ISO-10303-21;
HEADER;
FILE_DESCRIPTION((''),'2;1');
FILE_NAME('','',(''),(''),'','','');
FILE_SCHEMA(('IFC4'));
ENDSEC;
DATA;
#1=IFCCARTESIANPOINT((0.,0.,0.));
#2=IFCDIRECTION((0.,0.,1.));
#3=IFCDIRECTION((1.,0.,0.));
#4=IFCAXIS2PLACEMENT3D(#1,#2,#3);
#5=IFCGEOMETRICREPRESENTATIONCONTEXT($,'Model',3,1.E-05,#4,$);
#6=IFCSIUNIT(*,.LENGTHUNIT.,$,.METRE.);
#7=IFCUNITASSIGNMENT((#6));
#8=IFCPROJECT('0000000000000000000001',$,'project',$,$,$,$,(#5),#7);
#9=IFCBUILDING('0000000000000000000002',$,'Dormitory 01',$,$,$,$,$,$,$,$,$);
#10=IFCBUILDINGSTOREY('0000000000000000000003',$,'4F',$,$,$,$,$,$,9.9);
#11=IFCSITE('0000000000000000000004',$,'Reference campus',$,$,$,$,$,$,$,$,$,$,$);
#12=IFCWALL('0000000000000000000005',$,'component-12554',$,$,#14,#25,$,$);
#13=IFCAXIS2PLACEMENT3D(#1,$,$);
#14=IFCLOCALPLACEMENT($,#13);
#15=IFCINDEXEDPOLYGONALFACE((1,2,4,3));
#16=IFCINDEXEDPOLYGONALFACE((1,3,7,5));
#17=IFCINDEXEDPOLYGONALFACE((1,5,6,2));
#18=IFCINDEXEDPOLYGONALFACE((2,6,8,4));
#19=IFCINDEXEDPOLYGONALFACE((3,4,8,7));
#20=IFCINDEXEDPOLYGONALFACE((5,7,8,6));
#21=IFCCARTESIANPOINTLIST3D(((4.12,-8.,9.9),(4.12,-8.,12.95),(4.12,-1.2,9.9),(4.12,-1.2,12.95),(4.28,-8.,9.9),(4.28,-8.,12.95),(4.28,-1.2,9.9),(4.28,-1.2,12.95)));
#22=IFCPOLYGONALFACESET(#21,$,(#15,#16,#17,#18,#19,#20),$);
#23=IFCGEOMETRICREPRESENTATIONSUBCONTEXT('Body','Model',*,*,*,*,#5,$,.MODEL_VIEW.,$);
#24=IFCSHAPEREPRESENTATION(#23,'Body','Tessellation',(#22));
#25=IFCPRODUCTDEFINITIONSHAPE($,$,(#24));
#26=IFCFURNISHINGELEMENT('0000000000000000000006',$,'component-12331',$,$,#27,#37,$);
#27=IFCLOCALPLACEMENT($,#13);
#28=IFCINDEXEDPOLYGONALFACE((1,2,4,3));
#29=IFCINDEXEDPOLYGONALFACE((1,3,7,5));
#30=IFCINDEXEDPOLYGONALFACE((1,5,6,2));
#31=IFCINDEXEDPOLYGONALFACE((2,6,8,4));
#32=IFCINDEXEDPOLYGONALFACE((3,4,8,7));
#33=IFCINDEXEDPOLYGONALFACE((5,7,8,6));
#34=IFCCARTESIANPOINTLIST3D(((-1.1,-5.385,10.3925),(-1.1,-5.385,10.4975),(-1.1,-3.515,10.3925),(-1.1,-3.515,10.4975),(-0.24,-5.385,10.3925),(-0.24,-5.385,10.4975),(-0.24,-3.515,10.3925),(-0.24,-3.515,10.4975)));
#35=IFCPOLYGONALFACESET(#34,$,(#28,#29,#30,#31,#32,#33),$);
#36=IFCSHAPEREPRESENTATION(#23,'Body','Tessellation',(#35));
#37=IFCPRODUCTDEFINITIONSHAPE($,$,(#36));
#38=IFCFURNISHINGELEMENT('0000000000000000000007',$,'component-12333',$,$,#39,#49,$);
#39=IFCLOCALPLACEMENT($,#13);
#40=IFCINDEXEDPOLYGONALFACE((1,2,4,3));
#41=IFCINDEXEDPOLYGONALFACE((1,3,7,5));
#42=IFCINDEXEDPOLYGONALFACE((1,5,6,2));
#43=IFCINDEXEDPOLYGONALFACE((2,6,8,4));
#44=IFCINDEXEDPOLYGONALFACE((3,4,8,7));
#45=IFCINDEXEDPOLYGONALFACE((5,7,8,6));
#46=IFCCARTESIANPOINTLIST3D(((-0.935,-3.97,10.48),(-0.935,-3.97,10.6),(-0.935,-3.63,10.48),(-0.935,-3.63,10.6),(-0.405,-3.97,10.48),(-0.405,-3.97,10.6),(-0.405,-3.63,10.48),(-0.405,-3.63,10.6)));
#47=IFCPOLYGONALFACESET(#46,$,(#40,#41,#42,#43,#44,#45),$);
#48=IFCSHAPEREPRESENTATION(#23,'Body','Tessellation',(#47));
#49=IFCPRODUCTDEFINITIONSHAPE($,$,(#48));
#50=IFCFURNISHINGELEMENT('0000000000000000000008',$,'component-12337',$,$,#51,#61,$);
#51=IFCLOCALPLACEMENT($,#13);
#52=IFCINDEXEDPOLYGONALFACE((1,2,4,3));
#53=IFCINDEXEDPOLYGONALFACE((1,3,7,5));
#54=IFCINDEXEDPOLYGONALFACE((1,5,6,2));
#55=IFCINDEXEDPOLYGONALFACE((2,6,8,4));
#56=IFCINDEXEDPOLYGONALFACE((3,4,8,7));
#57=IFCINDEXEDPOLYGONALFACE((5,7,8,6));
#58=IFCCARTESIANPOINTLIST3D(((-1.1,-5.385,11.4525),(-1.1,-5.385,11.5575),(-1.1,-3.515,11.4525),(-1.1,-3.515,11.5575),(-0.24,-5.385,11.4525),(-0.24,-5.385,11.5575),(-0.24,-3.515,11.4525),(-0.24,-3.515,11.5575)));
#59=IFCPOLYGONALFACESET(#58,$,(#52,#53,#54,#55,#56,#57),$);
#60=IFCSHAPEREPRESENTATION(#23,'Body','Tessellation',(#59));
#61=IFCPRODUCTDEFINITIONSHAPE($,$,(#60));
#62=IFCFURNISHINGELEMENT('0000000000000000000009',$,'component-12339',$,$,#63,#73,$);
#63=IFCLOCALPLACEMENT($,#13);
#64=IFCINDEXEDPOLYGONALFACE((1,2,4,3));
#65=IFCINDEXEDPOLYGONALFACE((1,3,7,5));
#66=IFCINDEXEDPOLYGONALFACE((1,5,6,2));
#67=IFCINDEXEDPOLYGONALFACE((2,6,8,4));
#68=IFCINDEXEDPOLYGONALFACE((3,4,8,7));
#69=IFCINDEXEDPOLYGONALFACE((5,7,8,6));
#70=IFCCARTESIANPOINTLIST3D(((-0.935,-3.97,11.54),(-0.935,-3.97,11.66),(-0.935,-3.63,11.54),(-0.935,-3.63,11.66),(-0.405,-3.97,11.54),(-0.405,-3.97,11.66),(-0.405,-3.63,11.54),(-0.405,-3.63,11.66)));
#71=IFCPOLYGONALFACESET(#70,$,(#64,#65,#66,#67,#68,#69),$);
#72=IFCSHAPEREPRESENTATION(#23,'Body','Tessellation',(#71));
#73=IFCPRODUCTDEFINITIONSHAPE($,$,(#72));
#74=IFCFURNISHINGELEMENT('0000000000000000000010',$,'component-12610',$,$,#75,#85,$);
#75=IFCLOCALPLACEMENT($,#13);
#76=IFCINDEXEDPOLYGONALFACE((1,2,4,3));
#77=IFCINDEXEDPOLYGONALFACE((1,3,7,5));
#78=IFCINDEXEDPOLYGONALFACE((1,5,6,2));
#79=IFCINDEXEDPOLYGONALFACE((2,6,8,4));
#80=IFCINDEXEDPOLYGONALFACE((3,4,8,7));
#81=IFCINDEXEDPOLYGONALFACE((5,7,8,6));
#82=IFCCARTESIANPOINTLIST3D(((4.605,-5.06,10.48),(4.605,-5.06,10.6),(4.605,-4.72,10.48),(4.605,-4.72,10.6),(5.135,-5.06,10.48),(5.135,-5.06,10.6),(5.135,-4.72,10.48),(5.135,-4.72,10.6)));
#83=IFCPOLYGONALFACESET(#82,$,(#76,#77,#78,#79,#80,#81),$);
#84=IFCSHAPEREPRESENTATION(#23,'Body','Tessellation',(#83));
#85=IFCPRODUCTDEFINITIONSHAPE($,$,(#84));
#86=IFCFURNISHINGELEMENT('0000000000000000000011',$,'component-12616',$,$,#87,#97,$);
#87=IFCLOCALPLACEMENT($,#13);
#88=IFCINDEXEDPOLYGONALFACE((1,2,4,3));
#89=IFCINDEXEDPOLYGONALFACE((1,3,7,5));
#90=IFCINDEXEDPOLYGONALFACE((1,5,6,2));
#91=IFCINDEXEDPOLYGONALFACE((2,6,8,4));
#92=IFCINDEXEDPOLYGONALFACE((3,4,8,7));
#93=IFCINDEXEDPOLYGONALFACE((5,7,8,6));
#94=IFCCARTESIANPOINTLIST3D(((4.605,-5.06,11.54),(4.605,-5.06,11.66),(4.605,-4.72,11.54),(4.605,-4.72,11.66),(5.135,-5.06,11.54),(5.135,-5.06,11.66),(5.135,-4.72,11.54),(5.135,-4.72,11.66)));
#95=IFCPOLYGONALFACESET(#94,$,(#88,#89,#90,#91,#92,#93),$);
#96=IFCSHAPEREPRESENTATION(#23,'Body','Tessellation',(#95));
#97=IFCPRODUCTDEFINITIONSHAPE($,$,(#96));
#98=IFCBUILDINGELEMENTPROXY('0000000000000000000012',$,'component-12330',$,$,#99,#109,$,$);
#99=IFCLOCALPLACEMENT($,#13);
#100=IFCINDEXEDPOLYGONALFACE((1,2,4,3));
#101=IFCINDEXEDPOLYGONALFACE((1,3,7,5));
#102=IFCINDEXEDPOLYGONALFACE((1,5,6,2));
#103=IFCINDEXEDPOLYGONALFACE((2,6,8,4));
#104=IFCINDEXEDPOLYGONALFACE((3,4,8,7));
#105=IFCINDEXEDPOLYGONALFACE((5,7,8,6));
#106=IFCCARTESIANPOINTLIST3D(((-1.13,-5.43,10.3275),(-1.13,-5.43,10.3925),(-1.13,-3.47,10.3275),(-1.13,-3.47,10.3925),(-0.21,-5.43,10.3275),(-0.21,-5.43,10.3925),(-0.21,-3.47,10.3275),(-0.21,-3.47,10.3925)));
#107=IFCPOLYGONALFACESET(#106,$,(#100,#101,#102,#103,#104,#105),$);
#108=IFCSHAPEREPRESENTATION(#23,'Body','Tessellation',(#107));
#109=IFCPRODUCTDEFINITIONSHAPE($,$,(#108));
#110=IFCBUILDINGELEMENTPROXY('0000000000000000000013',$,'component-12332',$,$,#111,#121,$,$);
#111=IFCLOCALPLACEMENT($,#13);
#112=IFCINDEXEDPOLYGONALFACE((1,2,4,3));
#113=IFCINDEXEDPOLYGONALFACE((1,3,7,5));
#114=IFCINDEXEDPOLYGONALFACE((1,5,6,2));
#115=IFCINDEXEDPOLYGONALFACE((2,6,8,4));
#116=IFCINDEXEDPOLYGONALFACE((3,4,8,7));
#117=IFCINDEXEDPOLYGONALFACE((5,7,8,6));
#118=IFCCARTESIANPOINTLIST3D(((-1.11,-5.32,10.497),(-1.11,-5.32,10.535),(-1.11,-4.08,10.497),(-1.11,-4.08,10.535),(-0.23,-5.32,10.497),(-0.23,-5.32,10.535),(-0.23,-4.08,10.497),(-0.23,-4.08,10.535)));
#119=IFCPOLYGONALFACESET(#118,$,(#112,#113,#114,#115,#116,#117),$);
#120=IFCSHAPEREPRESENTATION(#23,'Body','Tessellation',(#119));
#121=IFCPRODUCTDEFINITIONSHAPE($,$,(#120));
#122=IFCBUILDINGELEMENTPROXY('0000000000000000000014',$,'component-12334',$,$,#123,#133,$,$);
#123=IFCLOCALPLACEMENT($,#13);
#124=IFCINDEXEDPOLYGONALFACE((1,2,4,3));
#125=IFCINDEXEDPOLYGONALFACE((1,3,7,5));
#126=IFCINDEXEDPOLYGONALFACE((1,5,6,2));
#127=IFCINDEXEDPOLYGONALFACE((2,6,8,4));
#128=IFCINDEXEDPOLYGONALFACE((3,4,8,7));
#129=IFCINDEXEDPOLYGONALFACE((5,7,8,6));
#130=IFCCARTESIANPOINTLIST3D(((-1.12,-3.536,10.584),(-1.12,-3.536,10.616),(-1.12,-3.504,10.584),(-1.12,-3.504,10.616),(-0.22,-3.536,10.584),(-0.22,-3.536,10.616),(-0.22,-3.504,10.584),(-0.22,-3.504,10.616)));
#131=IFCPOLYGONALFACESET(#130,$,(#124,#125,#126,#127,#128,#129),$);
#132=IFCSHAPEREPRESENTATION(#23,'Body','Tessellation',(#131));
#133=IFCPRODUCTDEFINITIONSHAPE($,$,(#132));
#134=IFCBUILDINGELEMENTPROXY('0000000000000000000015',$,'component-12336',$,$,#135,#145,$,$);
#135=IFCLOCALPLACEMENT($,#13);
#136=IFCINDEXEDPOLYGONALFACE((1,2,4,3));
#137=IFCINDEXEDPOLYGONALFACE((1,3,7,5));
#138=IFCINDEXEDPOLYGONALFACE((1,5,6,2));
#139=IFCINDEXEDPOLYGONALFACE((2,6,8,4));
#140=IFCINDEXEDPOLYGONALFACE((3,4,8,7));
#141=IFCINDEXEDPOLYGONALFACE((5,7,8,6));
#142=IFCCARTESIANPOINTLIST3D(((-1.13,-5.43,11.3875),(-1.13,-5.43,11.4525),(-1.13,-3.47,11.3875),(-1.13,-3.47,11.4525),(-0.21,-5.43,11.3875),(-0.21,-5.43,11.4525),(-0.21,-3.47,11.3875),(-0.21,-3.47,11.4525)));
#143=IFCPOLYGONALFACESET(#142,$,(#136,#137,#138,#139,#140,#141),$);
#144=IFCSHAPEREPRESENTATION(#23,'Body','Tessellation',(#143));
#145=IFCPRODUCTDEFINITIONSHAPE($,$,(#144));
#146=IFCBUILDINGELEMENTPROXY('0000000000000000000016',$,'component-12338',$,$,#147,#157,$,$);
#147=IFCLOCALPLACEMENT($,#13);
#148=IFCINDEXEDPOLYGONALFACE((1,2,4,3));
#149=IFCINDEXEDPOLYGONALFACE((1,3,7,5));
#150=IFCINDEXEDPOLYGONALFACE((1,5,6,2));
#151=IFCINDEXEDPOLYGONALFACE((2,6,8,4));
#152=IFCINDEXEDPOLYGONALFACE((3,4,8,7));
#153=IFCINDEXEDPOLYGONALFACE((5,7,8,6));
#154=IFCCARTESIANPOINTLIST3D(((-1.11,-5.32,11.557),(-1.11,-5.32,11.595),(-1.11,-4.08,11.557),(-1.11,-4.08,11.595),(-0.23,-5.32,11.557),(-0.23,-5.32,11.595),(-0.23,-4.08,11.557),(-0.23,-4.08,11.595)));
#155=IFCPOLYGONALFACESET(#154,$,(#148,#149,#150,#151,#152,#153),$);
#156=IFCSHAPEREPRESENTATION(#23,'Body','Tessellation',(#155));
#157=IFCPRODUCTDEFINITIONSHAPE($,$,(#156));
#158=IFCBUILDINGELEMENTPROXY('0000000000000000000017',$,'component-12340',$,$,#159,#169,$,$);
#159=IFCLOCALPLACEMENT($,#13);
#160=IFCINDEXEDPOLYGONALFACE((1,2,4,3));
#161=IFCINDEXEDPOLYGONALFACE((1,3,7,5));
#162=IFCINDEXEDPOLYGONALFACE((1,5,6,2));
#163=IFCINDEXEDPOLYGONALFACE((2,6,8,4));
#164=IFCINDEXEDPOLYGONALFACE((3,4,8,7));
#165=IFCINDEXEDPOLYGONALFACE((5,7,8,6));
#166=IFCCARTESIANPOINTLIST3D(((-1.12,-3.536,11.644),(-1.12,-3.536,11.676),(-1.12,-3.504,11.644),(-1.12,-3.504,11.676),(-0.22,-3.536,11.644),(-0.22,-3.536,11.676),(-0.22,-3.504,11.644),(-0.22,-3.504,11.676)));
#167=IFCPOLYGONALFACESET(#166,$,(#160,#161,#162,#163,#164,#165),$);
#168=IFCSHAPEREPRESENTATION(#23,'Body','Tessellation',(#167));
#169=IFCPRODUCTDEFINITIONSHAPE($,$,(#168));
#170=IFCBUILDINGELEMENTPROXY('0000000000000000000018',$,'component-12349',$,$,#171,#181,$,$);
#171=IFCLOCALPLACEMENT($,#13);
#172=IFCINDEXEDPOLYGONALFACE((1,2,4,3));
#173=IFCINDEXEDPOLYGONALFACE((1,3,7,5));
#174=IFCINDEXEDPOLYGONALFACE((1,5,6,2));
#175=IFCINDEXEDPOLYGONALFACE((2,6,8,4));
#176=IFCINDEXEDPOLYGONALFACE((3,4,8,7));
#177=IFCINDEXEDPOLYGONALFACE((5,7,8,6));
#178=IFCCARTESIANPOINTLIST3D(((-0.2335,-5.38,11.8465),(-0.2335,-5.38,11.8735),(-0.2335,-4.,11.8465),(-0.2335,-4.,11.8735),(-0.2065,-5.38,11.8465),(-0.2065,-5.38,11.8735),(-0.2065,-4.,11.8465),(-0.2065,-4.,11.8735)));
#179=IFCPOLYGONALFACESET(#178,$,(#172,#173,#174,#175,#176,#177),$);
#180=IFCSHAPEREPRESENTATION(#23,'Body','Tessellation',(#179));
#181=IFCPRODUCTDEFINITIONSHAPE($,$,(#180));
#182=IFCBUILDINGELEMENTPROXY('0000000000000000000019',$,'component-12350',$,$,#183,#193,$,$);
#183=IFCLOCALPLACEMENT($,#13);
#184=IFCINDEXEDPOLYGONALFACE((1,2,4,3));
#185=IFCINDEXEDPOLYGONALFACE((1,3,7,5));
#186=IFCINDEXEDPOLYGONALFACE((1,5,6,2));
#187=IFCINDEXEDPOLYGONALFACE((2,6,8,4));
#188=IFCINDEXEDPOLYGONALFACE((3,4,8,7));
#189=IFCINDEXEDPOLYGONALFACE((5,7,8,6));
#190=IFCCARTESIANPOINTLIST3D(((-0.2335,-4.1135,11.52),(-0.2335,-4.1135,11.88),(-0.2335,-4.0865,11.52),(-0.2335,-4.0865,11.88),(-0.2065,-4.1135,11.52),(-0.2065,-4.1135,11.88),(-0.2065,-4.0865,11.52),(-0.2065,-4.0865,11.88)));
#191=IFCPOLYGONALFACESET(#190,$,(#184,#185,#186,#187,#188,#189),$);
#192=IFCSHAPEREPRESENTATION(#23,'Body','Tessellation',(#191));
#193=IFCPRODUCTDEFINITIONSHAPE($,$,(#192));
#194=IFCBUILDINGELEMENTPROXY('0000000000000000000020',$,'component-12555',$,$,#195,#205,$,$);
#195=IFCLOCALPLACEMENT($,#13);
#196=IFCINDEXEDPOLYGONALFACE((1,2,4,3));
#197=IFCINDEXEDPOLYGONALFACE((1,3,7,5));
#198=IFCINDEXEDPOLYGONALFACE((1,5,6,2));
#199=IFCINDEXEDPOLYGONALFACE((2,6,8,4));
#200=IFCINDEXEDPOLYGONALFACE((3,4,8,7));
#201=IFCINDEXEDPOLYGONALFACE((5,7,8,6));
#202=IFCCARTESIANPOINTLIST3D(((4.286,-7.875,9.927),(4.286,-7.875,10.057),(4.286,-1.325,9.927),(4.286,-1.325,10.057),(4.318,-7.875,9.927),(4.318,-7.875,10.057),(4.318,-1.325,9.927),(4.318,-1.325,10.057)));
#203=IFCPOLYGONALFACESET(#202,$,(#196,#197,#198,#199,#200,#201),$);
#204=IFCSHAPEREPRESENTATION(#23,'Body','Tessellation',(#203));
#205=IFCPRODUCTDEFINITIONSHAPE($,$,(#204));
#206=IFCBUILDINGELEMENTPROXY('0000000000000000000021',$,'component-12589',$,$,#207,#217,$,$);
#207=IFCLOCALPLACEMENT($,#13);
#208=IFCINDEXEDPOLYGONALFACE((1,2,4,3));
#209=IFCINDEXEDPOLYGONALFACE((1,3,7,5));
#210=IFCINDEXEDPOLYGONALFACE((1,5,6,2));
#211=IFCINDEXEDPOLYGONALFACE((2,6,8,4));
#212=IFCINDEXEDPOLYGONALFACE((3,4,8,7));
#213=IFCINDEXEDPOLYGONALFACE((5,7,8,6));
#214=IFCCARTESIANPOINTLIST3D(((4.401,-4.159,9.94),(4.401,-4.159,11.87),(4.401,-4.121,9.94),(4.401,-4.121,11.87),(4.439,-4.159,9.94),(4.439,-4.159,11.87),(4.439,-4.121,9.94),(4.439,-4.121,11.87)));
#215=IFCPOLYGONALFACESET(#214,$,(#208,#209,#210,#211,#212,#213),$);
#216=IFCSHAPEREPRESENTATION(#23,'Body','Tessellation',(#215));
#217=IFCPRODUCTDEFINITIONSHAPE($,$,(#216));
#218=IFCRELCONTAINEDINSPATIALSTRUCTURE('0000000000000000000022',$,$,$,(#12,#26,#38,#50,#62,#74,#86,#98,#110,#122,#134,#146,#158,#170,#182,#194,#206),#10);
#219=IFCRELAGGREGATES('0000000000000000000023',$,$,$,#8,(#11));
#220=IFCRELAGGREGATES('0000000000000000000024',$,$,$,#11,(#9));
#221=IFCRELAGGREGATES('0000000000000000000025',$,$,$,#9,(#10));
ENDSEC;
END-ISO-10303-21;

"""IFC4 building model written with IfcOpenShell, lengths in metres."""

from ifc_helpers import new_model, si_unit, frame, origin, origin_with_axes, origin_2d, place, context, subcontext, project, spatial, rectangle, extrude, element, save


model = new_model("IFC4")

# Units and contexts
model_context = context("Model", 3, precision=1e-05, world=origin_with_axes())
body_context = subcontext(model_context, "Body", "Model", "MODEL_VIEW")
ifc_project = project(units=[si_unit("LENGTHUNIT", "METRE")], contexts=[model_context])

# Site, building, storey
site = spatial("IfcSite", under=ifc_project, Name="Reference campus")
building = spatial("IfcBuilding", under=site, Name="Dormitory 01")
storey = spatial("IfcBuildingStorey", under=building, Name="4F", Elevation=9.9)

# Wall
wall_placement = place(None, frame((4.2, -4.6, 9.9), z_axis=(0.0, 0.0, 1.0), x_axis=(1.0, 0.0, 0.0)))
element("IfcWall", 1, at=wall_placement, inside=storey, Name="component-12554", context=body_context, shape_type="SweptSolid", body=[
    extrude(rectangle(XDim=0.16, YDim=6.8, at=origin_2d()), origin(), (0.0, 0.0, 1.0), 3.05),
])

# Furnishing elements
furnishing_1_placement = place(None, frame((-0.67, -4.45, 10.3925), z_axis=(0.0, 0.0, 1.0), x_axis=(1.0, 0.0, 0.0)))
element("IfcFurnishingElement", 2, at=furnishing_1_placement, inside=storey, Name="component-12331", context=body_context, shape_type="SweptSolid", body=[
    extrude(rectangle(XDim=0.86, YDim=1.87, at=origin_2d()), origin(), (0.0, 0.0, 1.0), 0.105),
])
furnishing_2_placement = place(None, frame((-0.67, -3.8, 10.48), z_axis=(0.0, 0.0, 1.0), x_axis=(1.0, 0.0, 0.0)))
element("IfcFurnishingElement", 3, at=furnishing_2_placement, inside=storey, Name="component-12333", context=body_context, shape_type="SweptSolid", body=[
    extrude(rectangle(XDim=0.53, YDim=0.34, at=origin_2d()), origin(), (0.0, 0.0, 1.0), 0.12),
])
furnishing_3_placement = place(None, frame((-0.67, -4.45, 11.4525), z_axis=(0.0, 0.0, 1.0), x_axis=(1.0, 0.0, 0.0)))
element("IfcFurnishingElement", 4, at=furnishing_3_placement, inside=storey, Name="component-12337", context=body_context, shape_type="SweptSolid", body=[
    extrude(rectangle(XDim=0.86, YDim=1.87, at=origin_2d()), origin(), (0.0, 0.0, 1.0), 0.105),
])
for number, where, z_axis, x_axis, name in (
    (5, (-0.67, -3.8, 11.54), (0.0, 0.0, 1.0), (1.0, 0.0, 0.0), "component-12339"),
    (6, (4.87, -4.89, 10.48), (0.0, 0.0, 1.0), (1.0, 0.0, 0.0), "component-12610"),
    (7, (4.87, -4.89, 11.54), (0.0, 0.0, 1.0), (1.0, 0.0, 0.0), "component-12616"),
):
    element("IfcFurnishingElement", number, at=place(None, frame(where, z_axis=z_axis, x_axis=x_axis)), inside=storey, Name=name, context=body_context, shape_type="SweptSolid", body=[
        extrude(rectangle(XDim=0.53, YDim=0.34, at=origin_2d()), origin(), (0.0, 0.0, 1.0), 0.12),
    ])

# Building element proxies
proxy_1_placement = place(None, frame((-0.67, -4.45, 10.3275), z_axis=(0.0, 0.0, 1.0), x_axis=(1.0, 0.0, 0.0)))
element("IfcBuildingElementProxy", 8, at=proxy_1_placement, inside=storey, Name="component-12330", context=body_context, shape_type="SweptSolid", body=[
    extrude(rectangle(XDim=0.92, YDim=1.96, at=origin_2d()), origin(), (0.0, 0.0, 1.0), 0.065),
])
proxy_2_placement = place(None, frame((-0.67, -4.7, 10.497), z_axis=(0.0, 0.0, 1.0), x_axis=(1.0, 0.0, 0.0)))
element("IfcBuildingElementProxy", 9, at=proxy_2_placement, inside=storey, Name="component-12332", context=body_context, shape_type="SweptSolid", body=[
    extrude(rectangle(XDim=0.88, YDim=1.24, at=origin_2d()), origin(), (0.0, 0.0, 1.0), 0.038),
])
proxy_3_placement = place(None, frame((-0.67, -3.52, 10.584), z_axis=(0.0, 0.0, 1.0), x_axis=(1.0, 0.0, 0.0)))
element("IfcBuildingElementProxy", 10, at=proxy_3_placement, inside=storey, Name="component-12334", context=body_context, shape_type="SweptSolid", body=[
    extrude(rectangle(XDim=0.9, YDim=0.032, at=origin_2d()), origin(), (0.0, 0.0, 1.0), 0.032),
])
proxy_4_placement = place(None, frame((-0.67, -4.45, 11.3875), z_axis=(0.0, 0.0, 1.0), x_axis=(1.0, 0.0, 0.0)))
element("IfcBuildingElementProxy", 11, at=proxy_4_placement, inside=storey, Name="component-12336", context=body_context, shape_type="SweptSolid", body=[
    extrude(rectangle(XDim=0.92, YDim=1.96, at=origin_2d()), origin(), (0.0, 0.0, 1.0), 0.065),
])
proxy_5_placement = place(None, frame((-0.67, -4.7, 11.557), z_axis=(0.0, 0.0, 1.0), x_axis=(1.0, 0.0, 0.0)))
element("IfcBuildingElementProxy", 12, at=proxy_5_placement, inside=storey, Name="component-12338", context=body_context, shape_type="SweptSolid", body=[
    extrude(rectangle(XDim=0.88, YDim=1.24, at=origin_2d()), origin(), (0.0, 0.0, 1.0), 0.038),
])
proxy_6_placement = place(None, frame((-0.67, -3.52, 11.644), z_axis=(0.0, 0.0, 1.0), x_axis=(1.0, 0.0, 0.0)))
element("IfcBuildingElementProxy", 13, at=proxy_6_placement, inside=storey, Name="component-12340", context=body_context, shape_type="SweptSolid", body=[
    extrude(rectangle(XDim=0.9, YDim=0.032, at=origin_2d()), origin(), (0.0, 0.0, 1.0), 0.032),
])
proxy_7_placement = place(None, frame((-0.22, -4.69, 11.8465), z_axis=(0.0, 0.0, 1.0), x_axis=(1.0, 0.0, 0.0)))
element("IfcBuildingElementProxy", 14, at=proxy_7_placement, inside=storey, Name="component-12349", context=body_context, shape_type="SweptSolid", body=[
    extrude(rectangle(XDim=0.027, YDim=1.38, at=origin_2d()), origin(), (0.0, 0.0, 1.0), 0.027),
])
proxy_8_placement = place(None, frame((-0.22, -4.1, 11.52), z_axis=(0.0, 0.0, 1.0), x_axis=(1.0, 0.0, 0.0)))
element("IfcBuildingElementProxy", 15, at=proxy_8_placement, inside=storey, Name="component-12350", context=body_context, shape_type="SweptSolid", body=[
    extrude(rectangle(XDim=0.027, YDim=0.027, at=origin_2d()), origin(), (0.0, 0.0, 1.0), 0.36),
])
proxy_9_placement = place(None, frame((4.302, -4.6, 9.927), z_axis=(0.0, 0.0, 1.0), x_axis=(1.0, 0.0, 0.0)))
element("IfcBuildingElementProxy", 16, at=proxy_9_placement, inside=storey, Name="component-12555", context=body_context, shape_type="SweptSolid", body=[
    extrude(rectangle(XDim=0.032, YDim=6.55, at=origin_2d()), origin(), (0.0, 0.0, 1.0), 0.13),
])
proxy_10_placement = place(None, frame((4.42, -4.14, 9.94), z_axis=(0.0, 0.0, 1.0), x_axis=(1.0, 0.0, 0.0)))
element("IfcBuildingElementProxy", 17, at=proxy_10_placement, inside=storey, Name="component-12589", context=body_context, shape_type="SweptSolid", body=[
    extrude(rectangle(XDim=0.038, YDim=0.038, at=origin_2d()), origin(), (0.0, 0.0, 1.0), 1.93),
])

save(model, "model.ifc")
